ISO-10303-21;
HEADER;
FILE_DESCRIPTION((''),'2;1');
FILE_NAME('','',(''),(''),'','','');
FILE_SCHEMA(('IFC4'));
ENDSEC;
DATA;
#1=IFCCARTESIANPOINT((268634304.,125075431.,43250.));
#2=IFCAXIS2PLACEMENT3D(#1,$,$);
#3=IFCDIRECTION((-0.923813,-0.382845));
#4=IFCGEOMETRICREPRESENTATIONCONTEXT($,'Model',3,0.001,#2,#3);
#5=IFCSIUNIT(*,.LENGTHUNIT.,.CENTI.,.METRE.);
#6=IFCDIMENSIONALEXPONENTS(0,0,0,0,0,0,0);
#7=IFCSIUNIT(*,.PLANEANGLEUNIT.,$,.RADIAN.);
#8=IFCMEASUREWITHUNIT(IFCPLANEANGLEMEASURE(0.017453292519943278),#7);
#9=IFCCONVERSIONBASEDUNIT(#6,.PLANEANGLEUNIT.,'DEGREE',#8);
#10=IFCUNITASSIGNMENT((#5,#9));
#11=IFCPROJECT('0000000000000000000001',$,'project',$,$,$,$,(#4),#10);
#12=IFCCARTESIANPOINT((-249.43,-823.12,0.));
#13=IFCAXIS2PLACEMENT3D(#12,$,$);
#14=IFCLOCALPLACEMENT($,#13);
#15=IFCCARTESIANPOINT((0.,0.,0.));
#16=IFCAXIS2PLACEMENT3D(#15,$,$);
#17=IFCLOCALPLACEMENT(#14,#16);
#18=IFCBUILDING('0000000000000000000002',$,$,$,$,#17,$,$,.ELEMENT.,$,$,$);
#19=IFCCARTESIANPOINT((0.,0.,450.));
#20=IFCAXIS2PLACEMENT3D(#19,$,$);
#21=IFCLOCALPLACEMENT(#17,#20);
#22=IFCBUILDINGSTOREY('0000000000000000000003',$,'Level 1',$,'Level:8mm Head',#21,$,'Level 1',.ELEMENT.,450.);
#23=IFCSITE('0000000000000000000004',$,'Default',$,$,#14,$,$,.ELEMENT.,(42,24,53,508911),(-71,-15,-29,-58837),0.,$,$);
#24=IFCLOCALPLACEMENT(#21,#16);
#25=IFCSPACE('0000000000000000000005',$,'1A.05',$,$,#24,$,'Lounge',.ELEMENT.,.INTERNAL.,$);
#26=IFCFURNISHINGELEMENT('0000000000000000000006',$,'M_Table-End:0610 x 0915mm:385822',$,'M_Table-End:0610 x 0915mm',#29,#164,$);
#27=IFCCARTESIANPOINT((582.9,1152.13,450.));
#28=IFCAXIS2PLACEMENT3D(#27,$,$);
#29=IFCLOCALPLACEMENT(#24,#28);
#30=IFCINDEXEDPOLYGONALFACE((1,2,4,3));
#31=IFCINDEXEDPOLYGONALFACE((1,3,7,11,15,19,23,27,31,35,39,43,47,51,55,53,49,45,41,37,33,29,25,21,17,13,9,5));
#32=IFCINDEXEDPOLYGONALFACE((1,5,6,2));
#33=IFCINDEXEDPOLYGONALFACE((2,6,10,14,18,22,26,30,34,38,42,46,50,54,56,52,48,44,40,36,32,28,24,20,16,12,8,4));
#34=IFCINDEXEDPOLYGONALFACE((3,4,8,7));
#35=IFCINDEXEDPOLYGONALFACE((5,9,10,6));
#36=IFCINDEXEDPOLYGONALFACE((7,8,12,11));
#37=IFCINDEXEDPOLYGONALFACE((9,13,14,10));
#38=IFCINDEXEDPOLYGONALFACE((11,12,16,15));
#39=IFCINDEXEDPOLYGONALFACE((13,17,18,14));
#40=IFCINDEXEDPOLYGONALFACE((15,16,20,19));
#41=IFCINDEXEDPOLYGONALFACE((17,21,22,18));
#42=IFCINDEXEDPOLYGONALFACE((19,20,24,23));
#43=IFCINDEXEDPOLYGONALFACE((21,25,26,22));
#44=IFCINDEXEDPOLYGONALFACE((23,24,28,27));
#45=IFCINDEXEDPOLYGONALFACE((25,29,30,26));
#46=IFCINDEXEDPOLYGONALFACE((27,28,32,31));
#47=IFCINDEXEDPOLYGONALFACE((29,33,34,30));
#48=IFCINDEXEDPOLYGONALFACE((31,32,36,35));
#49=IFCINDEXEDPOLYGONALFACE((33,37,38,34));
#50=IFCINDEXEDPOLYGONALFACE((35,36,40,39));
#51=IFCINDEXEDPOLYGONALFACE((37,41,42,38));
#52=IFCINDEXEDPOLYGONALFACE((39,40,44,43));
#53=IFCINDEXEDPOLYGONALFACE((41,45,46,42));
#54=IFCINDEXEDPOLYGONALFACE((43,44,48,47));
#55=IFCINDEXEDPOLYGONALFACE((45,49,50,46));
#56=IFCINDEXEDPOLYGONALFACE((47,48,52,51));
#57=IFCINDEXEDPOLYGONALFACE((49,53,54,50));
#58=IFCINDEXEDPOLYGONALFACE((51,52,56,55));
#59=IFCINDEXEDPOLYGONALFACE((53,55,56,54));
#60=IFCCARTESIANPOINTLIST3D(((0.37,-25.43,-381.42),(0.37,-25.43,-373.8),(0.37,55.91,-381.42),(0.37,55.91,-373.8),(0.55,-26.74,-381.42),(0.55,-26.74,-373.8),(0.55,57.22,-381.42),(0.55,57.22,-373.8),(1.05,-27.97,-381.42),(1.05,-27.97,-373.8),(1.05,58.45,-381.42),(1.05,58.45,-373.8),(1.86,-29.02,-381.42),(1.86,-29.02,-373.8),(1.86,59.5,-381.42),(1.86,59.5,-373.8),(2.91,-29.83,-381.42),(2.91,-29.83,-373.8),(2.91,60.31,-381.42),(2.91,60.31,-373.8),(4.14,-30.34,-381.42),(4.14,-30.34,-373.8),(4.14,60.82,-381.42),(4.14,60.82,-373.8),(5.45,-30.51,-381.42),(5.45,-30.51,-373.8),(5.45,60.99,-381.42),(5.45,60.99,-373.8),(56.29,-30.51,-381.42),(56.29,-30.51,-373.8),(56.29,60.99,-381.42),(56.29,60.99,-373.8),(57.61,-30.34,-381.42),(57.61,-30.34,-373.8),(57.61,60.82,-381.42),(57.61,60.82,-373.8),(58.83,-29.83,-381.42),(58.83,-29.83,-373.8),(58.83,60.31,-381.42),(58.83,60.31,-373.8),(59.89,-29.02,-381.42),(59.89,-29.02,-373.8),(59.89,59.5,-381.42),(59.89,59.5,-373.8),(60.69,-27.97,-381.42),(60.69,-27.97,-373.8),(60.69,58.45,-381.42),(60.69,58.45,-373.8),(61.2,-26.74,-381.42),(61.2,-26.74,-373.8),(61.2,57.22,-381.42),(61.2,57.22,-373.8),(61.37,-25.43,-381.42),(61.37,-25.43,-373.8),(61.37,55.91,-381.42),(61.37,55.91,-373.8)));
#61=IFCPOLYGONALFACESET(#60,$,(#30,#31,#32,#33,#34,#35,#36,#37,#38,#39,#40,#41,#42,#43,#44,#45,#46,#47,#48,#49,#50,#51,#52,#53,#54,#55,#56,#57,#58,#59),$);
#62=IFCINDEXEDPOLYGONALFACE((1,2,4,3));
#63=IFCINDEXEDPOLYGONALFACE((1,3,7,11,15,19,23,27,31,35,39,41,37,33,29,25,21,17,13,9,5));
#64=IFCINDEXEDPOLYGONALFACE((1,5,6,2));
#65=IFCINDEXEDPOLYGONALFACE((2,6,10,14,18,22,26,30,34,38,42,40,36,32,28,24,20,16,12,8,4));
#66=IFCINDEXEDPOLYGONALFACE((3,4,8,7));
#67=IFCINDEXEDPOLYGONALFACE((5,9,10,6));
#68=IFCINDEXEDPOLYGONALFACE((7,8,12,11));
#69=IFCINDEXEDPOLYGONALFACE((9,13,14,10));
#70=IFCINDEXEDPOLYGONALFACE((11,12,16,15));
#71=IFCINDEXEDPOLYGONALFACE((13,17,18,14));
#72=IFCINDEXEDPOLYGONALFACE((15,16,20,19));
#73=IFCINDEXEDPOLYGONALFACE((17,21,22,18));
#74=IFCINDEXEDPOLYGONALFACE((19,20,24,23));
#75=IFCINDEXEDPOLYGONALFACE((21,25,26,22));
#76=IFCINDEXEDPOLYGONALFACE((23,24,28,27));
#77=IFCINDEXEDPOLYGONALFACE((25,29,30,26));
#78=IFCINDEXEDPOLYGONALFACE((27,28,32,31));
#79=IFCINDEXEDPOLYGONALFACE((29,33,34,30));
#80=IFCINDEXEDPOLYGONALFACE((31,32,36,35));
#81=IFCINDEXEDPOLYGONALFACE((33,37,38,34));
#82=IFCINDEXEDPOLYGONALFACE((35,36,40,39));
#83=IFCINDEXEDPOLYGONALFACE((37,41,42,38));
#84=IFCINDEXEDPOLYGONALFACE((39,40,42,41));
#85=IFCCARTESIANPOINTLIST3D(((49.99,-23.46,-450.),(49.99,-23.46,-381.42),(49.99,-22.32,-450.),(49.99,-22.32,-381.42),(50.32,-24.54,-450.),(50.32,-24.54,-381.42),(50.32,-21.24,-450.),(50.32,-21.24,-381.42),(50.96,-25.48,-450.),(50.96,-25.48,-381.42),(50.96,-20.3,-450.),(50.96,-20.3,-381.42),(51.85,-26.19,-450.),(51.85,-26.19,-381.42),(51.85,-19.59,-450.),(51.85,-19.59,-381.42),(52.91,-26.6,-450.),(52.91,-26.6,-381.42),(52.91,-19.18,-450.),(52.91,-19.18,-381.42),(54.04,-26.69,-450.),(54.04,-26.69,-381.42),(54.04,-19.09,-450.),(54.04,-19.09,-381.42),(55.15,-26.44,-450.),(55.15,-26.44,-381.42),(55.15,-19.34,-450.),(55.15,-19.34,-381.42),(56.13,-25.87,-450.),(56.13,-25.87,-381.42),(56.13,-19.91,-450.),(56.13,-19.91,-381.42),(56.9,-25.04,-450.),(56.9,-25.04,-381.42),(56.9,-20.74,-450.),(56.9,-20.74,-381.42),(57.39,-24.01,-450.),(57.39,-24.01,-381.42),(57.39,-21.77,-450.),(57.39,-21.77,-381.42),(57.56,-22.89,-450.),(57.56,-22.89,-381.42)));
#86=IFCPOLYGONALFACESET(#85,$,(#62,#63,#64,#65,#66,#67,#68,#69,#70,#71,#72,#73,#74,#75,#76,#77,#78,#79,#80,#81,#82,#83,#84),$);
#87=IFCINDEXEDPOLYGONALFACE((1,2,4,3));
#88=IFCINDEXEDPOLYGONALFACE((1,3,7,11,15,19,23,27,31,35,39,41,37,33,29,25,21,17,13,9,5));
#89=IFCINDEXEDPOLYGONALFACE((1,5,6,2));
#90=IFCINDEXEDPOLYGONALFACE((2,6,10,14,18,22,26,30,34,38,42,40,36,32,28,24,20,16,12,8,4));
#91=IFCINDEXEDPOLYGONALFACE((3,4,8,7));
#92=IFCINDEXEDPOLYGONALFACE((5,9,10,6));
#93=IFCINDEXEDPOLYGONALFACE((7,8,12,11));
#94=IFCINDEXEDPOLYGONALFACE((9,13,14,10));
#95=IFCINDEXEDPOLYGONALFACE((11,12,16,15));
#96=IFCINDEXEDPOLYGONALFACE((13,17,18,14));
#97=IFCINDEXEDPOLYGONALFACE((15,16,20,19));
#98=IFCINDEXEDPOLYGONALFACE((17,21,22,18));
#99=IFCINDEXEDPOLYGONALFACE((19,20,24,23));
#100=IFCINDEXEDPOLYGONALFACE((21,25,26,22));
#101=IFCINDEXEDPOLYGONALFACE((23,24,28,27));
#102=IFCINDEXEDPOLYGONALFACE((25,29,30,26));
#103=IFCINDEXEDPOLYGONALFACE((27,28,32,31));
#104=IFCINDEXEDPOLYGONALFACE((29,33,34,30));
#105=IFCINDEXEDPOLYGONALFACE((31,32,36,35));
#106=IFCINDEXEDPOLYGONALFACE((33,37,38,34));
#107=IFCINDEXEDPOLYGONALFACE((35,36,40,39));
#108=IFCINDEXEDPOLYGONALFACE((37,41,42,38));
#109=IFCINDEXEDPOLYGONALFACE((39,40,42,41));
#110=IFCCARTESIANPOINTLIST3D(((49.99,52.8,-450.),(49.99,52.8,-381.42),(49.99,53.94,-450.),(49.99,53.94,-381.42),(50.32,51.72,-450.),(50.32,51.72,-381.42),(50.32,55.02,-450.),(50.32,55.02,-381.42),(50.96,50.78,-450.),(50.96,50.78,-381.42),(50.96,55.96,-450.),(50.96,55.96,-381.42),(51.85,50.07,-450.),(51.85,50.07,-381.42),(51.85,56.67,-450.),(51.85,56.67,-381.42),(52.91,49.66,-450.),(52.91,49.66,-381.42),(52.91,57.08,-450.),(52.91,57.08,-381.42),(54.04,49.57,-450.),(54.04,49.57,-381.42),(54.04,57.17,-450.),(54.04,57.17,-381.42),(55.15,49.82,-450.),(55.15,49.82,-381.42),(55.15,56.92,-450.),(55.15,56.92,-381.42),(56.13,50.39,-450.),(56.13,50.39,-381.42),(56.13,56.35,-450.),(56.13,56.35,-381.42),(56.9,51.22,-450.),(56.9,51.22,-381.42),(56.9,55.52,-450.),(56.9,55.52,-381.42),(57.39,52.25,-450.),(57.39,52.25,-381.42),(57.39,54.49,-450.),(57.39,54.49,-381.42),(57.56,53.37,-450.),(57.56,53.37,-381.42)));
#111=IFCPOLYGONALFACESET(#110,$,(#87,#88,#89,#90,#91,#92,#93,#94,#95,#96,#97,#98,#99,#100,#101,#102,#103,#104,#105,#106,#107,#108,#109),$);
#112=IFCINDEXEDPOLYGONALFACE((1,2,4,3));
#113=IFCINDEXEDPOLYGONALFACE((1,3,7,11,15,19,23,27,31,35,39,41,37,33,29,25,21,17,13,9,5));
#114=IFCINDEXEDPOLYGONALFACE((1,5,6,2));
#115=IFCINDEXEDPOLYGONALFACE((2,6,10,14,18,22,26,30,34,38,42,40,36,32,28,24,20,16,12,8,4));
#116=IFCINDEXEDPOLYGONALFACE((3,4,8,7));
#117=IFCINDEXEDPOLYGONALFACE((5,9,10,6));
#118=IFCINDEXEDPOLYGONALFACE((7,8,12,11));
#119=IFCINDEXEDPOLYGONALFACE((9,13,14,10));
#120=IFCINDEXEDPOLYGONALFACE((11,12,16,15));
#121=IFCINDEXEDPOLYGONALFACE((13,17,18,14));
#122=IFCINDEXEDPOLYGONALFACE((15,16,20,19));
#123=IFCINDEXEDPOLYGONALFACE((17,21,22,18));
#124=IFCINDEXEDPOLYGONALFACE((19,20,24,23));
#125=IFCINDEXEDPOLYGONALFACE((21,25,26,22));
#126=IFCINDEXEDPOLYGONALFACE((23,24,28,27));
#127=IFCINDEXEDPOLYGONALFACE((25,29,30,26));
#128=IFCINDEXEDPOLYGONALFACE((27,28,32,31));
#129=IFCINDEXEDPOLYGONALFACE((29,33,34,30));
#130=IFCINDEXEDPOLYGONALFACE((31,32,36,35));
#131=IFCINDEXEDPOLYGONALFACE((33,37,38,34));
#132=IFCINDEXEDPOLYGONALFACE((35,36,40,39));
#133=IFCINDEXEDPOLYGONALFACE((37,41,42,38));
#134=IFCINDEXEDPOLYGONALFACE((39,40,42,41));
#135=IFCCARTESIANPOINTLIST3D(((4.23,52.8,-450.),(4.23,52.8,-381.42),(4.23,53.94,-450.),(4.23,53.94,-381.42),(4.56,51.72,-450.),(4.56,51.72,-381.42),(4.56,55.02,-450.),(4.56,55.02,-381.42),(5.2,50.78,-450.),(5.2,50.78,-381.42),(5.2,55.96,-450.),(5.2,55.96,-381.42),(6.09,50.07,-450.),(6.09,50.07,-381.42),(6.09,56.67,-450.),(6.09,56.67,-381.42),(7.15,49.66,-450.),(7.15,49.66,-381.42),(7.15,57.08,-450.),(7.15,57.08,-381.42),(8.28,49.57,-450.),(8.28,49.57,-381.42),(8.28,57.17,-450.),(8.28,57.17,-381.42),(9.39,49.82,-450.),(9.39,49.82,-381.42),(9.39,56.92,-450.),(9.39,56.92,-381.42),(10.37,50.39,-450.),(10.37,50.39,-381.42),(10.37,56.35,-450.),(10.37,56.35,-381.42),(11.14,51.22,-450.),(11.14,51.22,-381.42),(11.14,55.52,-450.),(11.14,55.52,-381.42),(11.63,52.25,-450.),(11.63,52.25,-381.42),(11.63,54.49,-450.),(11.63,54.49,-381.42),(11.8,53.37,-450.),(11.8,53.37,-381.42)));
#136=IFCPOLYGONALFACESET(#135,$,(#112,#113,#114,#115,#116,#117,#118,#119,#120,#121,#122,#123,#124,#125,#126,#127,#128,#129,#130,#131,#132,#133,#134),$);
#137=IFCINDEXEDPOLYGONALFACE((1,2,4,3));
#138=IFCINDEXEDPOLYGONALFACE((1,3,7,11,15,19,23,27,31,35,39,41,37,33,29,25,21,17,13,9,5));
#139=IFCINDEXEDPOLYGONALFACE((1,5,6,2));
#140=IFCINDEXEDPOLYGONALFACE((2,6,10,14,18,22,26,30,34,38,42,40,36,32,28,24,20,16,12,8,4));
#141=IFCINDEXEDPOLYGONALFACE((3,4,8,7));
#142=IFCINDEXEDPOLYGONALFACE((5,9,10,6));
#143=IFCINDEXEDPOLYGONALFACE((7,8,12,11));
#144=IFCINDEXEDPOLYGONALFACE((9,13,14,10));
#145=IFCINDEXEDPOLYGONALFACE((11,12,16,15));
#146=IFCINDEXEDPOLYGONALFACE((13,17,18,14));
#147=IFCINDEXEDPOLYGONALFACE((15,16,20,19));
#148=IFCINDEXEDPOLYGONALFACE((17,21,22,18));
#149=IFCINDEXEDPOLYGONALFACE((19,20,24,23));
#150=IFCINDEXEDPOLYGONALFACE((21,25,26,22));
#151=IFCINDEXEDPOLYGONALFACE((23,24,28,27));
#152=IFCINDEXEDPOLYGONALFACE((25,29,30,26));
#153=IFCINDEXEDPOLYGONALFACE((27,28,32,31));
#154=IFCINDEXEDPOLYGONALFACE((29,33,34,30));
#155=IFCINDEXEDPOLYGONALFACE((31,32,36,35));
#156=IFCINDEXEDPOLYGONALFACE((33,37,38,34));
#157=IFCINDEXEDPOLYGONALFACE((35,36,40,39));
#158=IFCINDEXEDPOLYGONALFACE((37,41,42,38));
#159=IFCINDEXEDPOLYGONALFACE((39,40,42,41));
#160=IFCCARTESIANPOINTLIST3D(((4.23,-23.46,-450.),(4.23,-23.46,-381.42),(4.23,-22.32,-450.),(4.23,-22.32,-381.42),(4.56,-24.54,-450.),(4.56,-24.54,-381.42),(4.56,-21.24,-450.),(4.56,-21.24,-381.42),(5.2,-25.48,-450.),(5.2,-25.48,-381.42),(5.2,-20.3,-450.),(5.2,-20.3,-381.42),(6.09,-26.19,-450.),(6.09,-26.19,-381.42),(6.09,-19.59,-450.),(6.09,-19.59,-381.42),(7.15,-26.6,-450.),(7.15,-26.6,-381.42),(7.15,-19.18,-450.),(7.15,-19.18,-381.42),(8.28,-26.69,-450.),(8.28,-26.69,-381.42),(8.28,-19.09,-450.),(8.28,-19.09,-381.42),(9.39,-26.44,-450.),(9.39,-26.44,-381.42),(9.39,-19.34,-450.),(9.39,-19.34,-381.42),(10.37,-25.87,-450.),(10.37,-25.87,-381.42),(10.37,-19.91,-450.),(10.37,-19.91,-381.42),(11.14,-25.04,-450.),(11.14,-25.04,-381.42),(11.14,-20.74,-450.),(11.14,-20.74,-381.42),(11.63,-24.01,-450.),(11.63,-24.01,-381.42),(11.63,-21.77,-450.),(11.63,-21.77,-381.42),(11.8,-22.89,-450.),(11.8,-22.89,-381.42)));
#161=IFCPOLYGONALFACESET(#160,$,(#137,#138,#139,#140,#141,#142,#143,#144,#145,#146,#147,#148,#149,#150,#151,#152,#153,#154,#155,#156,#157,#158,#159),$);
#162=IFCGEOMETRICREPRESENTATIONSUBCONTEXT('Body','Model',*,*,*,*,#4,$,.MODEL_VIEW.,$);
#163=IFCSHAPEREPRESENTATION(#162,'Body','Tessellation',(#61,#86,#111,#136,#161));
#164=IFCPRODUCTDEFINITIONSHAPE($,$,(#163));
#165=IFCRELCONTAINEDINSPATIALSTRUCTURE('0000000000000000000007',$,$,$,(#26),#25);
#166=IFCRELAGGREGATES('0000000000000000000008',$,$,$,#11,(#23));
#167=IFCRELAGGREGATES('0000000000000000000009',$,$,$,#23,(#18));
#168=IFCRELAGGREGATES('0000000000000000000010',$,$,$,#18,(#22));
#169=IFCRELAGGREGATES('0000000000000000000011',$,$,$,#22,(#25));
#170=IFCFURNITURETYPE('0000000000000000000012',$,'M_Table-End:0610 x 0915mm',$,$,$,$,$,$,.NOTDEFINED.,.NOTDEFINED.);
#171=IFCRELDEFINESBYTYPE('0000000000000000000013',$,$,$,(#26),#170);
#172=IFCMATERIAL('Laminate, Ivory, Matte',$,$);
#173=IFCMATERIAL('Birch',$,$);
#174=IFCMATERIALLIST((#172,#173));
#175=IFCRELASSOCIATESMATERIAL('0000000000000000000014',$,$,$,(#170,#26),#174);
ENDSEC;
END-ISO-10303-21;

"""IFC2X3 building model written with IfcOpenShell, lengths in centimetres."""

from ifc_helpers import new_model, entity, si_unit, converted_unit, direction, frame, frame_2d, origin, place, context, subcontext, project, spatial, polyline, circle_curve, parameter, trimmed, segment, composite_curve, circle, outline, extrude, source, transform, mapped, material, material_list, type_object, type_shapes, element, save


model = new_model("IFC2X3")

# Units and contexts
model_context = context("Model", 3, precision=0.001, world=frame((268634304.0, 125075431.0, 43250.0)), true_north=direction((-0.923813, -0.382845)))
body_context = subcontext(model_context, "Body", "Model", "MODEL_VIEW")
ifc_project = project(units=[si_unit("LENGTHUNIT", "METRE", prefix="CENTI"), converted_unit("PLANEANGLEUNIT", "DEGREE", entity("IfcPlaneAngleMeasure", 0.017453292519943278), si_unit("PLANEANGLEUNIT", "RADIAN"), dimensions=[0, 0, 0, 0, 0, 0, 0])], contexts=[model_context])

# Site, building, storey
site_placement = place(None, frame((-249.43, -823.12, 0.0)))
site = spatial("IfcSite", under=ifc_project, at=site_placement, Name="Default", CompositionType="ELEMENT", RefLatitude=(42, 24, 53, 508911), RefLongitude=(-71, -15, -29, -58837), RefElevation=0.0)
building_placement = place(site_placement, origin())
building = spatial("IfcBuilding", under=site, at=building_placement, CompositionType="ELEMENT")
storey_placement = place(building_placement, frame((0.0, 0.0, 450.0)))
storey = spatial("IfcBuildingStorey", under=building, at=storey_placement, Name="Level 1", ObjectType="Level:8mm Head", LongName="Level 1", CompositionType="ELEMENT", Elevation=450.0)

# Shared definitions
space_1_placement = place(storey_placement, origin())
space_1 = spatial("IfcSpace", under=storey, at=space_1_placement, Name="1A.05", LongName="Lounge", CompositionType="ELEMENT", InteriorOrExteriorSpace="INTERNAL")

# Furnishing element
ifc_material_1 = material(Name="Laminate, Ivory, Matte")
ifc_material_2 = material(Name="Birch")
ifc_material_list_1 = material_list([ifc_material_1, ifc_material_2])
furniture_type_1 = type_object("IfcFurnitureType", Name="M_Table-End:0610 x 0915mm", AssemblyPlace="NOTDEFINED", material=ifc_material_list_1)
shared_shape_1 = source(origin(), body_context, "Body", "SweptSolid", [
    extrude(outline(composite_curve([segment(trimmed(circle_curve(frame_2d((25.42, -40.67), x_axis=(1.0, 0.0)), 5.08), [parameter(270.0)], [parameter(0.0)], True, "PARAMETER"), True, "CONTINUOUS"), segment(polyline([(30.5, -40.67), (30.5, 40.67)]), True, "CONTINUOUS"), segment(trimmed(circle_curve(frame_2d((25.42, 40.67), x_axis=(1.0, 0.0)), 5.08), [parameter(360.0)], [parameter(90.0)], True, "PARAMETER"), True, "CONTINUOUS"), segment(polyline([(25.42, 45.75), (-25.42, 45.75)]), True, "CONTINUOUS"), segment(trimmed(circle_curve(frame_2d((-25.42, 40.67), x_axis=(1.0, 0.0)), 5.08), [parameter(90.0)], [parameter(180.0)], True, "PARAMETER"), True, "CONTINUOUS"), segment(polyline([(-30.5, 40.67), (-30.5, -40.67)]), True, "CONTINUOUS"), segment(trimmed(circle_curve(frame_2d((-25.42, -40.67), x_axis=(1.0, 0.0)), 5.08), [parameter(180.0)], [parameter(270.0)], True, "PARAMETER"), True, "CONTINUOUS"), segment(polyline([(-25.42, -45.75), (25.42, -45.75)]), True, "CONTINUOUS")], self_intersect=False)), frame((30.87, 15.24, -381.42)), (0.0, 0.0, 1.0), 7.62),
    extrude(circle(Radius=3.81, at=frame_2d((0.0, 0.0), x_axis=(1.0, 0.0))), frame((53.75, -22.89, -450.0)), (0.0, 0.0, 1.0), 68.58),
    extrude(circle(Radius=3.81, at=frame_2d((0.0, 0.0), x_axis=(1.0, 0.0))), frame((53.75, 53.37, -450.0)), (0.0, 0.0, 1.0), 68.58),
    extrude(circle(Radius=3.81, at=frame_2d((0.0, 0.0), x_axis=(1.0, 0.0))), frame((7.99, 53.37, -450.0)), (0.0, 0.0, 1.0), 68.58),
    extrude(circle(Radius=3.81, at=frame_2d((0.0, 0.0), x_axis=(1.0, 0.0))), frame((7.99, -22.89, -450.0)), (0.0, 0.0, 1.0), 68.58),
])
type_shapes(furniture_type_1, [shared_shape_1])
furnishing_1_placement = place(space_1_placement, frame((582.9, 1152.13, 450.0)))
element("IfcFurnishingElement", 1, at=furnishing_1_placement, inside=space_1, type_object=furniture_type_1, material=ifc_material_list_1, Name="M_Table-End:0610 x 0915mm:385822", ObjectType="M_Table-End:0610 x 0915mm", context=body_context, shape_type="MappedRepresentation", body=[
    mapped(shared_shape_1, transform((0.0, 0.0, 0.0), scale=1.0)),
])

save(model, "model.ifc")
